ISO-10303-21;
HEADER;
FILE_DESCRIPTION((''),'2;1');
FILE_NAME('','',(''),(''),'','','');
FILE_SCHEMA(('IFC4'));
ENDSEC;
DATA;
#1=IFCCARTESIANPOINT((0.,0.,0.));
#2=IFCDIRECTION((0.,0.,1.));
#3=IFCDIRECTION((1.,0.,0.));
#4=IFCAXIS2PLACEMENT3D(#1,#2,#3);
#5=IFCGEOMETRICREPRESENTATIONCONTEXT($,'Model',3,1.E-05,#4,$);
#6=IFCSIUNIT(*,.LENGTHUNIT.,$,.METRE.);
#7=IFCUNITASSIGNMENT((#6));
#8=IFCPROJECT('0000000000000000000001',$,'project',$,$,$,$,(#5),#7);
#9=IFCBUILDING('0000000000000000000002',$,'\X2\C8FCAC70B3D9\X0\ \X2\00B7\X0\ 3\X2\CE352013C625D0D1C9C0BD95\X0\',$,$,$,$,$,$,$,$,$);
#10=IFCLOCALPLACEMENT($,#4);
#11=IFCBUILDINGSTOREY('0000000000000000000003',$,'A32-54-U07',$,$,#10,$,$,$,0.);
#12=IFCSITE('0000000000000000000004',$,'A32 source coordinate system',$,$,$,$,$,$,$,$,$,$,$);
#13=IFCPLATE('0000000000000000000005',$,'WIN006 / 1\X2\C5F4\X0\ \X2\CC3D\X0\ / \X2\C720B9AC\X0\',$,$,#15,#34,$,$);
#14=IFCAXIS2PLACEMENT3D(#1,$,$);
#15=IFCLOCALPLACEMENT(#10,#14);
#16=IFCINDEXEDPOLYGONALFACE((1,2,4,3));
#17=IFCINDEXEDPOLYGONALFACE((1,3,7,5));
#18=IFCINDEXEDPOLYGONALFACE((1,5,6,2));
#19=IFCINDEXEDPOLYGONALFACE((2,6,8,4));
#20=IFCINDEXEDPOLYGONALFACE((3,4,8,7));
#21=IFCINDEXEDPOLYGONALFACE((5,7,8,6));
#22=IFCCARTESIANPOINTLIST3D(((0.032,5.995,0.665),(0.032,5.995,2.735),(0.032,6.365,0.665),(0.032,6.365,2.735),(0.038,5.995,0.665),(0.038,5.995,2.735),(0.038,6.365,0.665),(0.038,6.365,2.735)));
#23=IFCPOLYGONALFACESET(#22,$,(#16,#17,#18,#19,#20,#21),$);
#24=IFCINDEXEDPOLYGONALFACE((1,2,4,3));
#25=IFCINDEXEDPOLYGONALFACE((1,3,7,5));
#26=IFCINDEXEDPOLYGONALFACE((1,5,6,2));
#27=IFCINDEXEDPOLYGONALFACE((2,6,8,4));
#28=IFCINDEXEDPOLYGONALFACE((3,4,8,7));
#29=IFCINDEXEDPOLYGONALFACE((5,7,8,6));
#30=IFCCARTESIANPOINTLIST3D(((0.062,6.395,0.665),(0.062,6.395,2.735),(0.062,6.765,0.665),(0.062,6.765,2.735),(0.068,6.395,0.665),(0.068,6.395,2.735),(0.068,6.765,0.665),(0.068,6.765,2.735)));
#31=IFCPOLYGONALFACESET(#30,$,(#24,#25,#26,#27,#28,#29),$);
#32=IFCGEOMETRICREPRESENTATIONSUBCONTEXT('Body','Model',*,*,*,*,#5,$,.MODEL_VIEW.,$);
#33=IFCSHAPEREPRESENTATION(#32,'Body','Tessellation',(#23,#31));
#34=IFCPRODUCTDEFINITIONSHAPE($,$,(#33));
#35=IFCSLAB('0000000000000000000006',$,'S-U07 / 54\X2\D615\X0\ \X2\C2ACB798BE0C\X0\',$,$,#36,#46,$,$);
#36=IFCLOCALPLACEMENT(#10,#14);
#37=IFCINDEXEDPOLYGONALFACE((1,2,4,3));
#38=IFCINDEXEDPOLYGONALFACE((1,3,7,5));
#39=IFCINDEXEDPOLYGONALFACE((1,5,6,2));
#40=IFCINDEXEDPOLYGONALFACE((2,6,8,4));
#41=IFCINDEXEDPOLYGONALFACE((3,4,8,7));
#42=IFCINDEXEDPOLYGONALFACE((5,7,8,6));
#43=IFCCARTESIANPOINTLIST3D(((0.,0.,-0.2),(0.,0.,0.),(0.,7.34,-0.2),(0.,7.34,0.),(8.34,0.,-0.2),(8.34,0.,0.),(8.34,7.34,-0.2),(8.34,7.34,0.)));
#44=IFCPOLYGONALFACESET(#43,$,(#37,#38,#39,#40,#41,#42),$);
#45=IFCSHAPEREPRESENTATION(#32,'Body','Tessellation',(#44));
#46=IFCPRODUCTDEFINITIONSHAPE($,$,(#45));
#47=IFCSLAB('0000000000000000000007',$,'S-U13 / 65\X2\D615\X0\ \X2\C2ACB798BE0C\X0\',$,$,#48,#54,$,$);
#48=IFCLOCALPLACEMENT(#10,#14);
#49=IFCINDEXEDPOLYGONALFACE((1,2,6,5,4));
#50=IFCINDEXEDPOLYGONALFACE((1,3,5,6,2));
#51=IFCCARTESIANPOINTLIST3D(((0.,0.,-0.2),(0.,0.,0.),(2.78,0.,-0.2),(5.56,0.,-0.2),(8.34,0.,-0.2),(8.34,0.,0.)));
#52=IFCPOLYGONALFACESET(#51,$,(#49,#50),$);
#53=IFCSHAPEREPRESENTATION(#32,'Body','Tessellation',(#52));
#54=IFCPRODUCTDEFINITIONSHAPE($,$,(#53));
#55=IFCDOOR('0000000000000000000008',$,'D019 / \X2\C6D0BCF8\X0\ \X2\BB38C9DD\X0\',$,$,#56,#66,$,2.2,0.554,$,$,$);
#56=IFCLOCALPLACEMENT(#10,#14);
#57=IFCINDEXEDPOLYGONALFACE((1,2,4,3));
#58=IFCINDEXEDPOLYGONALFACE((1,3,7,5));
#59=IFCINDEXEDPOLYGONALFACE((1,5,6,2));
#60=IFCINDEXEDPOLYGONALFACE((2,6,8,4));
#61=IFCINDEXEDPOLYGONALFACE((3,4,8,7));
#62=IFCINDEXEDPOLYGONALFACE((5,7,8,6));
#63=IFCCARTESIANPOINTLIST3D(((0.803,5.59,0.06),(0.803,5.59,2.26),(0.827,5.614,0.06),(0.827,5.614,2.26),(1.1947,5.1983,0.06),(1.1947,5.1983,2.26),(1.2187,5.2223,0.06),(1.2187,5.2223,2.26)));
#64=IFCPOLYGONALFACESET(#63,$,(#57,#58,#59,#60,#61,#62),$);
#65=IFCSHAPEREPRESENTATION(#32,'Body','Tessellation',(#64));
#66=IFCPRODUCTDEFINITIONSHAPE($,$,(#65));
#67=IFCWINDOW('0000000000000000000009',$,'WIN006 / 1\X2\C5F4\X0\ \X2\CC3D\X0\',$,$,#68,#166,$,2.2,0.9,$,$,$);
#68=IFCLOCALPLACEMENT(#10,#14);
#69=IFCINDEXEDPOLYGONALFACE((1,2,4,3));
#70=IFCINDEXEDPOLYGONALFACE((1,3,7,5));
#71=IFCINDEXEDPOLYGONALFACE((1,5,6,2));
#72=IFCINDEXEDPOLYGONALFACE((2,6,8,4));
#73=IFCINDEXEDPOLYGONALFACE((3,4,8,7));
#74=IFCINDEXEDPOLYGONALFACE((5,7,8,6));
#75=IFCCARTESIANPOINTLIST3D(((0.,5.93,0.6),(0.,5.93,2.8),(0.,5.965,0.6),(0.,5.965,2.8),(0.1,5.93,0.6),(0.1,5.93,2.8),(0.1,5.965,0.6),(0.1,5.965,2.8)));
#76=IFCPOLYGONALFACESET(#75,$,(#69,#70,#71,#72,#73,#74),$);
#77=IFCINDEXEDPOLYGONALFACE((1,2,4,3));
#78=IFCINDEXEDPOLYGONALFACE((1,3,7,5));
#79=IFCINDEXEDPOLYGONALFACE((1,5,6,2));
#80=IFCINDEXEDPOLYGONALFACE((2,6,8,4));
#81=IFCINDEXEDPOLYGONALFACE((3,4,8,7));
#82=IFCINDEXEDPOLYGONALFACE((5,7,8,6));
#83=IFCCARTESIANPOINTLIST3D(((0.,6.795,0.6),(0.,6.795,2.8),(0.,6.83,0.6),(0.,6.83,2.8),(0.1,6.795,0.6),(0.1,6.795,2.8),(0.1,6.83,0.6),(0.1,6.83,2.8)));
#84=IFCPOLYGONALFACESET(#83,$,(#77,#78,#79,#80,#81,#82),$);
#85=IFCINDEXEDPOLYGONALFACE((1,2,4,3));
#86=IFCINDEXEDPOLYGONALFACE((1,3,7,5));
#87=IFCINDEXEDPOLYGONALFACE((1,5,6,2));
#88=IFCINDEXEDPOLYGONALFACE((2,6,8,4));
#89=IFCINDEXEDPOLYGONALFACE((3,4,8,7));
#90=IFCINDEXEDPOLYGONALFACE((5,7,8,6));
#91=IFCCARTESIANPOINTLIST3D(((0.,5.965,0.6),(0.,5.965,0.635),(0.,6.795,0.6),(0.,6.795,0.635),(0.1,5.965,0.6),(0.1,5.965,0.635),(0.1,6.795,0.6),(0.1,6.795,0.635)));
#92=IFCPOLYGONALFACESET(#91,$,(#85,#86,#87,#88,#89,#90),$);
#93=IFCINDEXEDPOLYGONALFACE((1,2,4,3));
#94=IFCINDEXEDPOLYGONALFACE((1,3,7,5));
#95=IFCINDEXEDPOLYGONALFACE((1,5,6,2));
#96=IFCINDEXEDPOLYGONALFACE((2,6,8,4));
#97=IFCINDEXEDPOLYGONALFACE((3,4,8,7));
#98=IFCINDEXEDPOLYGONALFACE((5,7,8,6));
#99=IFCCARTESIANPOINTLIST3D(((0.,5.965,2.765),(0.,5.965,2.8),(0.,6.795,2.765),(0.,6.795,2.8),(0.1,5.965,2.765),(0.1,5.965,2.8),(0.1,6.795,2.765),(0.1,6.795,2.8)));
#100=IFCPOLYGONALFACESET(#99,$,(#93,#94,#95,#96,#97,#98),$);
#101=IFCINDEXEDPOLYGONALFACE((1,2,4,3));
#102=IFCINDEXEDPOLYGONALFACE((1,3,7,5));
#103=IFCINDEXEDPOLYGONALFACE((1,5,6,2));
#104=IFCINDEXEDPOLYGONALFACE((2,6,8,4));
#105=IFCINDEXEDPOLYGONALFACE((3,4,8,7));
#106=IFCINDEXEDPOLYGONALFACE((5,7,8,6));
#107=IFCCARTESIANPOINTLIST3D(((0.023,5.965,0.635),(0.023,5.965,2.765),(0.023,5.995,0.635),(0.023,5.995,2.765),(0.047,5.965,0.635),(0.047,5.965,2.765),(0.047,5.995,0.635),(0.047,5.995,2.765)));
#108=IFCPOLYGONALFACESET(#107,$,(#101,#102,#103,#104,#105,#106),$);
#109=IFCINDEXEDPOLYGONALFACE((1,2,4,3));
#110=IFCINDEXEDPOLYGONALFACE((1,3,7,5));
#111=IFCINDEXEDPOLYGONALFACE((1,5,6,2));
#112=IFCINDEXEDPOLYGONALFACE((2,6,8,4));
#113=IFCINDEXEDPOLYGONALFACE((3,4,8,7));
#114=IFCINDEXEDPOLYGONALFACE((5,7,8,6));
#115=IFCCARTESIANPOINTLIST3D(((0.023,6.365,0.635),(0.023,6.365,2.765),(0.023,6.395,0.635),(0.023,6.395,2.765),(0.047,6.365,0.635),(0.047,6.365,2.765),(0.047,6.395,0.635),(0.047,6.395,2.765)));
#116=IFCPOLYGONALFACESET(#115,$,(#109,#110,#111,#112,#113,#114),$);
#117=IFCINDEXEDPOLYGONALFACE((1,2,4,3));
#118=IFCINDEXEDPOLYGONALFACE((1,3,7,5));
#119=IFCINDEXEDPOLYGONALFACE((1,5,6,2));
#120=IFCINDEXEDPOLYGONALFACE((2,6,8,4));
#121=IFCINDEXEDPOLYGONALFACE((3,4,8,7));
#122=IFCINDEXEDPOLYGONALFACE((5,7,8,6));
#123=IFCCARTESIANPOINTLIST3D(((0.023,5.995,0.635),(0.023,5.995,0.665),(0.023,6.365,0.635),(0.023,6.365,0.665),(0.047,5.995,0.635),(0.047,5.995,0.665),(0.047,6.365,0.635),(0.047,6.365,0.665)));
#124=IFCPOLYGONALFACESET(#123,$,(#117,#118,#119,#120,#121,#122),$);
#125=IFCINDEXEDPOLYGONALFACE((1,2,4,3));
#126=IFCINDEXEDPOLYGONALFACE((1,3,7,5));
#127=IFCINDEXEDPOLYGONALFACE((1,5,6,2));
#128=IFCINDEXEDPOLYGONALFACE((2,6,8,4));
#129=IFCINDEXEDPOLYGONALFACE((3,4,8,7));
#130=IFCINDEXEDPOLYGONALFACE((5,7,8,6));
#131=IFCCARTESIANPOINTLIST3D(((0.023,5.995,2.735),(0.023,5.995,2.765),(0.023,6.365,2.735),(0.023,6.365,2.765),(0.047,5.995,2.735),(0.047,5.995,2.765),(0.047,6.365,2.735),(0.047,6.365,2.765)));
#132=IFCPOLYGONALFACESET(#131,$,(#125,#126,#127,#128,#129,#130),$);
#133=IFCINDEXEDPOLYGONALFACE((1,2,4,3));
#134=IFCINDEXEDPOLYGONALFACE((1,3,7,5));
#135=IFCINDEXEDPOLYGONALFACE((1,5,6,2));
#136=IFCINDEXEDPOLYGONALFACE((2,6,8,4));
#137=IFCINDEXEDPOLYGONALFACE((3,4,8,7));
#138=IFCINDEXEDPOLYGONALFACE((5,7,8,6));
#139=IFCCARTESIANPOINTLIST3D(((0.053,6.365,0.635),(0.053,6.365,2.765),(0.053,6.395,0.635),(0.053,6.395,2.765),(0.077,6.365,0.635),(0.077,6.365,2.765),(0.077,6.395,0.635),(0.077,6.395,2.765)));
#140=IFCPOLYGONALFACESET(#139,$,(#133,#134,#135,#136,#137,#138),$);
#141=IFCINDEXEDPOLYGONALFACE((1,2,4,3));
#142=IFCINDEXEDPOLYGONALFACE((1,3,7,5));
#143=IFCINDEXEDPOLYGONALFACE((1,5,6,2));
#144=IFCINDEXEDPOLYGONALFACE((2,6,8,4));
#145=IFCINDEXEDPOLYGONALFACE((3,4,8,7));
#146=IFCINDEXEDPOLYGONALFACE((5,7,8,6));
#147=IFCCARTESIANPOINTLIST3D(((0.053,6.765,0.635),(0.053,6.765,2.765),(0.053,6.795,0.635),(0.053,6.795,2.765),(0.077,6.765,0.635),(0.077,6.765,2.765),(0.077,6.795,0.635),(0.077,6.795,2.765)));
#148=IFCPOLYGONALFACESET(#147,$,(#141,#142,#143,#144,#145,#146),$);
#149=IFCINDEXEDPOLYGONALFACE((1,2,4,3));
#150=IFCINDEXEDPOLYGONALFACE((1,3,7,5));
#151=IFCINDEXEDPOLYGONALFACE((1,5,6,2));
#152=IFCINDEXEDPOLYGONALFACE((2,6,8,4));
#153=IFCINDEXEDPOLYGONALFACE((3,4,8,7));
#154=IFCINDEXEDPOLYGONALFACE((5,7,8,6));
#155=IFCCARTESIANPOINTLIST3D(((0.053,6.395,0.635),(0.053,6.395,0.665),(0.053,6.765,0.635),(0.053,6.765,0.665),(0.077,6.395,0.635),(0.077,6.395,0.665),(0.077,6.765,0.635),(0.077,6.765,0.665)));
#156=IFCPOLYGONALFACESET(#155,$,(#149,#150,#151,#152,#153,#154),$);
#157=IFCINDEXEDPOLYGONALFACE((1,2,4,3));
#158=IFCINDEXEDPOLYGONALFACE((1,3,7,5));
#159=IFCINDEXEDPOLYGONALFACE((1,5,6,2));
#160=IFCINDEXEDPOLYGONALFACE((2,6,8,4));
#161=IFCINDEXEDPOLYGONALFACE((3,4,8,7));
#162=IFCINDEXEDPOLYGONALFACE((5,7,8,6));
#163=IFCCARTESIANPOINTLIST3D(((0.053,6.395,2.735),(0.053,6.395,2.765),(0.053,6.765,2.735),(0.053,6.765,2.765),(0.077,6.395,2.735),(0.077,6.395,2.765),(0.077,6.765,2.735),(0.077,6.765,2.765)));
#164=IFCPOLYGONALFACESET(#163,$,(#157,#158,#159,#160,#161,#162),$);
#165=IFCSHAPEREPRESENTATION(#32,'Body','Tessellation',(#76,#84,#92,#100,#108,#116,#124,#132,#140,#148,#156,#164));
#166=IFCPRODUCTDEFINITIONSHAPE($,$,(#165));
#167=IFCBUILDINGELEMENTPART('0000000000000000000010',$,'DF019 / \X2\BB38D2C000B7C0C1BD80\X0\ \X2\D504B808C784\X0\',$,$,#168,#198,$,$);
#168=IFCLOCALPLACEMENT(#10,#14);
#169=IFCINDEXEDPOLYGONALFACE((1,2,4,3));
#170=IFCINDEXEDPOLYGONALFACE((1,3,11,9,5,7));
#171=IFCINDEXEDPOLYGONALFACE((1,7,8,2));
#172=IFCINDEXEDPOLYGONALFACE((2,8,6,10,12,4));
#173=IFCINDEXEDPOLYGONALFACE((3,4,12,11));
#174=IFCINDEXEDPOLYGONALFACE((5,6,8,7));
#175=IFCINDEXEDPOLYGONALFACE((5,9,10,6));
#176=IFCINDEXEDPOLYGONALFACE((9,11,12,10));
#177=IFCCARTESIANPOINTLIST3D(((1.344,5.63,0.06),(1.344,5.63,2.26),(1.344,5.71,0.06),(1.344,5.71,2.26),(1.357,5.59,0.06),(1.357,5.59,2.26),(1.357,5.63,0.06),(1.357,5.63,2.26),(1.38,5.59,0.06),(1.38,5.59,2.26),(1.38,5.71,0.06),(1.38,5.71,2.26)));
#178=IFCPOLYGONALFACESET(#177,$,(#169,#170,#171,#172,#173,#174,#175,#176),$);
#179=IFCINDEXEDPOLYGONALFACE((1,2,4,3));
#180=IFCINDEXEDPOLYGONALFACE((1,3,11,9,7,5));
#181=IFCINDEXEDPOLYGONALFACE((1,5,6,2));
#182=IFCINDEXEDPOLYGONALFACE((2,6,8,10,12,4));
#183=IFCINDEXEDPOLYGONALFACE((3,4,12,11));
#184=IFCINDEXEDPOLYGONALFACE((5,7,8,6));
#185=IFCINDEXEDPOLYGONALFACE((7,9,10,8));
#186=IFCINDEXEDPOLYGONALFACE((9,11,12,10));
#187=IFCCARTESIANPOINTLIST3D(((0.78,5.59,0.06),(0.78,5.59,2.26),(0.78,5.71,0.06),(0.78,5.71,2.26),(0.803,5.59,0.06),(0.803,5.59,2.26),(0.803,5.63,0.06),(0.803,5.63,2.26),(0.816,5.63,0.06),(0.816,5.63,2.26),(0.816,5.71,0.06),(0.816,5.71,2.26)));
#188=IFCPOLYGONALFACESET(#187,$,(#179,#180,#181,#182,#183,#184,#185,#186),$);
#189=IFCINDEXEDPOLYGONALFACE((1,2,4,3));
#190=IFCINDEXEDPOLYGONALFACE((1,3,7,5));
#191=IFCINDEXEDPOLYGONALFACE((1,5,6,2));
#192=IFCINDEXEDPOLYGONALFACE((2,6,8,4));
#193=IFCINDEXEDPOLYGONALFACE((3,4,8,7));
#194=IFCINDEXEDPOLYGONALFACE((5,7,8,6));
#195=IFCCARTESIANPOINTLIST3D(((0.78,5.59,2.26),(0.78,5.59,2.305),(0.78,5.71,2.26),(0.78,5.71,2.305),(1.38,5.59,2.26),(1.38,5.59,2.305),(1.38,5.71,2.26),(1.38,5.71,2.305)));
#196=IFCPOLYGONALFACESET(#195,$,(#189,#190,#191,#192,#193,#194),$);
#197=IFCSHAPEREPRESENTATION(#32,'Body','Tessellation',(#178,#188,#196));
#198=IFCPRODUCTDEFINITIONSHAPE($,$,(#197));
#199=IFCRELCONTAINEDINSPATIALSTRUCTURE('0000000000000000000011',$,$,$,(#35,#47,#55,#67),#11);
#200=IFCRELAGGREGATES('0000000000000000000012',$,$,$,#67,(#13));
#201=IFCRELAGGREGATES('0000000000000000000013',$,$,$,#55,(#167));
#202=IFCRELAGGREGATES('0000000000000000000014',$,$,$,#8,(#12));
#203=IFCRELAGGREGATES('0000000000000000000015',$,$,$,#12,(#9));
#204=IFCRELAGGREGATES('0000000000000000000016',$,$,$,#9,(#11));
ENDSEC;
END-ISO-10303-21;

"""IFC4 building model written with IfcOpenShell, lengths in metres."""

from ifc_helpers import new_model, si_unit, frame, origin_with_axes, place, context, subcontext, project, spatial, polyline, outline, extrude, element, aggregate, save


model = new_model("IFC4")

# Units and contexts
model_context = context("Model", 3, precision=1e-05, world=origin_with_axes())
body_context = subcontext(model_context, "Body", "Model", "MODEL_VIEW")
ifc_project = project(units=[si_unit("LENGTHUNIT", "METRE")], contexts=[model_context])

# Plate
storey_placement = place(None, origin_with_axes())
window_1_placement = place(storey_placement, origin_with_axes())
plate_1_placement = place(window_1_placement, origin_with_axes())
plate_1 = element("IfcPlate", 1, at=plate_1_placement, Name="WIN006 / 1열 창 / 유리", context=body_context, shape_type="SweptSolid", body=[
    extrude(outline(polyline([(0.032, 5.995), (0.032, 6.365), (0.038, 6.365), (0.038, 5.995), (0.032, 5.995)])), frame((0.0, 0.0, 0.665)), (0.0, 0.0, 1.0), 2.07),
    extrude(outline(polyline([(0.062, 6.395), (0.062, 6.765), (0.068, 6.765), (0.068, 6.395), (0.062, 6.395)])), frame((0.0, 0.0, 0.665)), (0.0, 0.0, 1.0), 2.07),
])

# Site, building, storey
site = spatial("IfcSite", under=ifc_project, Name="A32 source coordinate system")
building = spatial("IfcBuilding", under=site, Name="주거동 · 3층–옥탑지붕")
storey = spatial("IfcBuildingStorey", under=building, at=storey_placement, Name="A32-54-U07", Elevation=0.0)

# Slabs
slab_1_placement = place(storey_placement, origin_with_axes())
element("IfcSlab", 2, at=slab_1_placement, inside=storey, Name="S-U07 / 54형 슬래브", context=body_context, shape_type="SweptSolid", body=[
    extrude(outline(polyline([(0.0, 0.0), (0.0, 7.34), (8.34, 7.34), (8.34, 0.0), (0.0, 0.0)])), frame((0.0, 0.0, -0.2)), (0.0, 0.0, 1.0), 0.2),
])
slab_2_placement = place(storey_placement, origin_with_axes())
element("IfcSlab", 3, at=slab_2_placement, inside=storey, Name="S-U13 / 65형 슬래브", context=body_context, shape_type="SweptSolid", body=[
    extrude(outline(polyline([(0.0, 0.0), (8.34, 0.0), (8.34, 0.0), (0.0, 0.0), (0.0, 0.0)])), frame((0.0, 0.0, -0.2)), (0.0, 0.0, 1.0), 0.2),
])

# Door
door_1_placement = place(storey_placement, origin_with_axes())
door_1 = element("IfcDoor", 4, at=door_1_placement, inside=storey, Name="D019 / 원본 문짝", OverallHeight=2.2, OverallWidth=0.554, context=body_context, shape_type="SweptSolid", body=[
    extrude(outline(polyline([(1.2187, 5.2223), (1.1947, 5.1983), (0.803, 5.59), (0.827, 5.614), (1.2187, 5.2223)])), frame((0.0, 0.0, 0.06)), (0.0, 0.0, 1.0), 2.2),
])

# Window
window_1 = element("IfcWindow", 5, at=window_1_placement, inside=storey, Name="WIN006 / 1열 창", OverallHeight=2.2, OverallWidth=0.9, context=body_context, shape_type="SweptSolid", body=[
    extrude(outline(polyline([(0.0, 5.93), (0.0, 5.965), (0.1, 5.965), (0.1, 5.93), (0.0, 5.93)])), frame((0.0, 0.0, 0.6)), (0.0, 0.0, 1.0), 2.2),
    extrude(outline(polyline([(0.0, 6.795), (0.0, 6.83), (0.1, 6.83), (0.1, 6.795), (0.0, 6.795)])), frame((0.0, 0.0, 0.6)), (0.0, 0.0, 1.0), 2.2),
    extrude(outline(polyline([(0.0, 5.965), (0.0, 6.795), (0.1, 6.795), (0.1, 5.965), (0.0, 5.965)])), frame((0.0, 0.0, 0.6)), (0.0, 0.0, 1.0), 0.035),
    extrude(outline(polyline([(0.0, 5.965), (0.0, 6.795), (0.1, 6.795), (0.1, 5.965), (0.0, 5.965)])), frame((0.0, 0.0, 2.765)), (0.0, 0.0, 1.0), 0.035),
    extrude(outline(polyline([(0.023, 5.965), (0.023, 5.995), (0.047, 5.995), (0.047, 5.965), (0.023, 5.965)])), frame((0.0, 0.0, 0.635)), (0.0, 0.0, 1.0), 2.13),
    extrude(outline(polyline([(0.023, 6.365), (0.023, 6.395), (0.047, 6.395), (0.047, 6.365), (0.023, 6.365)])), frame((0.0, 0.0, 0.635)), (0.0, 0.0, 1.0), 2.13),
    extrude(outline(polyline([(0.023, 5.995), (0.023, 6.365), (0.047, 6.365), (0.047, 5.995), (0.023, 5.995)])), frame((0.0, 0.0, 0.635)), (0.0, 0.0, 1.0), 0.03),
    extrude(outline(polyline([(0.023, 5.995), (0.023, 6.365), (0.047, 6.365), (0.047, 5.995), (0.023, 5.995)])), frame((0.0, 0.0, 2.735)), (0.0, 0.0, 1.0), 0.03),
    extrude(outline(polyline([(0.053, 6.365), (0.053, 6.395), (0.077, 6.395), (0.077, 6.365), (0.053, 6.365)])), frame((0.0, 0.0, 0.635)), (0.0, 0.0, 1.0), 2.13),
    extrude(outline(polyline([(0.053, 6.765), (0.053, 6.795), (0.077, 6.795), (0.077, 6.765), (0.053, 6.765)])), frame((0.0, 0.0, 0.635)), (0.0, 0.0, 1.0), 2.13),
    extrude(outline(polyline([(0.053, 6.395), (0.053, 6.765), (0.077, 6.765), (0.077, 6.395), (0.053, 6.395)])), frame((0.0, 0.0, 0.635)), (0.0, 0.0, 1.0), 0.03),
    extrude(outline(polyline([(0.053, 6.395), (0.053, 6.765), (0.077, 6.765), (0.077, 6.395), (0.053, 6.395)])), frame((0.0, 0.0, 2.735)), (0.0, 0.0, 1.0), 0.03),
])
aggregate(window_1, [plate_1])

# Building element part
building_element_part_1_placement = place(door_1_placement, origin_with_axes())
building_element_part_1 = element("IfcBuildingElementPart", 6, at=building_element_part_1_placement, Name="DF019 / 문틀·상부 프레임", context=body_context, shape_type="SweptSolid", body=[
    extrude(outline(polyline([(1.38, 5.59), (1.357, 5.59), (1.357, 5.63), (1.344, 5.63), (1.344, 5.71), (1.38, 5.71), (1.38, 5.59)])), frame((0.0, 0.0, 0.06)), (0.0, 0.0, 1.0), 2.2),
    extrude(outline(polyline([(0.816, 5.71), (0.816, 5.63), (0.803, 5.63), (0.803, 5.59), (0.78, 5.59), (0.78, 5.71), (0.816, 5.71)])), frame((0.0, 0.0, 0.06)), (0.0, 0.0, 1.0), 2.2),
    extrude(outline(polyline([(0.78, 5.59), (0.78, 5.71), (1.38, 5.71), (1.38, 5.59), (0.78, 5.59)])), frame((0.0, 0.0, 2.26)), (0.0, 0.0, 1.0), 0.045),
])
aggregate(door_1, [building_element_part_1])

save(model, "model.ifc")
